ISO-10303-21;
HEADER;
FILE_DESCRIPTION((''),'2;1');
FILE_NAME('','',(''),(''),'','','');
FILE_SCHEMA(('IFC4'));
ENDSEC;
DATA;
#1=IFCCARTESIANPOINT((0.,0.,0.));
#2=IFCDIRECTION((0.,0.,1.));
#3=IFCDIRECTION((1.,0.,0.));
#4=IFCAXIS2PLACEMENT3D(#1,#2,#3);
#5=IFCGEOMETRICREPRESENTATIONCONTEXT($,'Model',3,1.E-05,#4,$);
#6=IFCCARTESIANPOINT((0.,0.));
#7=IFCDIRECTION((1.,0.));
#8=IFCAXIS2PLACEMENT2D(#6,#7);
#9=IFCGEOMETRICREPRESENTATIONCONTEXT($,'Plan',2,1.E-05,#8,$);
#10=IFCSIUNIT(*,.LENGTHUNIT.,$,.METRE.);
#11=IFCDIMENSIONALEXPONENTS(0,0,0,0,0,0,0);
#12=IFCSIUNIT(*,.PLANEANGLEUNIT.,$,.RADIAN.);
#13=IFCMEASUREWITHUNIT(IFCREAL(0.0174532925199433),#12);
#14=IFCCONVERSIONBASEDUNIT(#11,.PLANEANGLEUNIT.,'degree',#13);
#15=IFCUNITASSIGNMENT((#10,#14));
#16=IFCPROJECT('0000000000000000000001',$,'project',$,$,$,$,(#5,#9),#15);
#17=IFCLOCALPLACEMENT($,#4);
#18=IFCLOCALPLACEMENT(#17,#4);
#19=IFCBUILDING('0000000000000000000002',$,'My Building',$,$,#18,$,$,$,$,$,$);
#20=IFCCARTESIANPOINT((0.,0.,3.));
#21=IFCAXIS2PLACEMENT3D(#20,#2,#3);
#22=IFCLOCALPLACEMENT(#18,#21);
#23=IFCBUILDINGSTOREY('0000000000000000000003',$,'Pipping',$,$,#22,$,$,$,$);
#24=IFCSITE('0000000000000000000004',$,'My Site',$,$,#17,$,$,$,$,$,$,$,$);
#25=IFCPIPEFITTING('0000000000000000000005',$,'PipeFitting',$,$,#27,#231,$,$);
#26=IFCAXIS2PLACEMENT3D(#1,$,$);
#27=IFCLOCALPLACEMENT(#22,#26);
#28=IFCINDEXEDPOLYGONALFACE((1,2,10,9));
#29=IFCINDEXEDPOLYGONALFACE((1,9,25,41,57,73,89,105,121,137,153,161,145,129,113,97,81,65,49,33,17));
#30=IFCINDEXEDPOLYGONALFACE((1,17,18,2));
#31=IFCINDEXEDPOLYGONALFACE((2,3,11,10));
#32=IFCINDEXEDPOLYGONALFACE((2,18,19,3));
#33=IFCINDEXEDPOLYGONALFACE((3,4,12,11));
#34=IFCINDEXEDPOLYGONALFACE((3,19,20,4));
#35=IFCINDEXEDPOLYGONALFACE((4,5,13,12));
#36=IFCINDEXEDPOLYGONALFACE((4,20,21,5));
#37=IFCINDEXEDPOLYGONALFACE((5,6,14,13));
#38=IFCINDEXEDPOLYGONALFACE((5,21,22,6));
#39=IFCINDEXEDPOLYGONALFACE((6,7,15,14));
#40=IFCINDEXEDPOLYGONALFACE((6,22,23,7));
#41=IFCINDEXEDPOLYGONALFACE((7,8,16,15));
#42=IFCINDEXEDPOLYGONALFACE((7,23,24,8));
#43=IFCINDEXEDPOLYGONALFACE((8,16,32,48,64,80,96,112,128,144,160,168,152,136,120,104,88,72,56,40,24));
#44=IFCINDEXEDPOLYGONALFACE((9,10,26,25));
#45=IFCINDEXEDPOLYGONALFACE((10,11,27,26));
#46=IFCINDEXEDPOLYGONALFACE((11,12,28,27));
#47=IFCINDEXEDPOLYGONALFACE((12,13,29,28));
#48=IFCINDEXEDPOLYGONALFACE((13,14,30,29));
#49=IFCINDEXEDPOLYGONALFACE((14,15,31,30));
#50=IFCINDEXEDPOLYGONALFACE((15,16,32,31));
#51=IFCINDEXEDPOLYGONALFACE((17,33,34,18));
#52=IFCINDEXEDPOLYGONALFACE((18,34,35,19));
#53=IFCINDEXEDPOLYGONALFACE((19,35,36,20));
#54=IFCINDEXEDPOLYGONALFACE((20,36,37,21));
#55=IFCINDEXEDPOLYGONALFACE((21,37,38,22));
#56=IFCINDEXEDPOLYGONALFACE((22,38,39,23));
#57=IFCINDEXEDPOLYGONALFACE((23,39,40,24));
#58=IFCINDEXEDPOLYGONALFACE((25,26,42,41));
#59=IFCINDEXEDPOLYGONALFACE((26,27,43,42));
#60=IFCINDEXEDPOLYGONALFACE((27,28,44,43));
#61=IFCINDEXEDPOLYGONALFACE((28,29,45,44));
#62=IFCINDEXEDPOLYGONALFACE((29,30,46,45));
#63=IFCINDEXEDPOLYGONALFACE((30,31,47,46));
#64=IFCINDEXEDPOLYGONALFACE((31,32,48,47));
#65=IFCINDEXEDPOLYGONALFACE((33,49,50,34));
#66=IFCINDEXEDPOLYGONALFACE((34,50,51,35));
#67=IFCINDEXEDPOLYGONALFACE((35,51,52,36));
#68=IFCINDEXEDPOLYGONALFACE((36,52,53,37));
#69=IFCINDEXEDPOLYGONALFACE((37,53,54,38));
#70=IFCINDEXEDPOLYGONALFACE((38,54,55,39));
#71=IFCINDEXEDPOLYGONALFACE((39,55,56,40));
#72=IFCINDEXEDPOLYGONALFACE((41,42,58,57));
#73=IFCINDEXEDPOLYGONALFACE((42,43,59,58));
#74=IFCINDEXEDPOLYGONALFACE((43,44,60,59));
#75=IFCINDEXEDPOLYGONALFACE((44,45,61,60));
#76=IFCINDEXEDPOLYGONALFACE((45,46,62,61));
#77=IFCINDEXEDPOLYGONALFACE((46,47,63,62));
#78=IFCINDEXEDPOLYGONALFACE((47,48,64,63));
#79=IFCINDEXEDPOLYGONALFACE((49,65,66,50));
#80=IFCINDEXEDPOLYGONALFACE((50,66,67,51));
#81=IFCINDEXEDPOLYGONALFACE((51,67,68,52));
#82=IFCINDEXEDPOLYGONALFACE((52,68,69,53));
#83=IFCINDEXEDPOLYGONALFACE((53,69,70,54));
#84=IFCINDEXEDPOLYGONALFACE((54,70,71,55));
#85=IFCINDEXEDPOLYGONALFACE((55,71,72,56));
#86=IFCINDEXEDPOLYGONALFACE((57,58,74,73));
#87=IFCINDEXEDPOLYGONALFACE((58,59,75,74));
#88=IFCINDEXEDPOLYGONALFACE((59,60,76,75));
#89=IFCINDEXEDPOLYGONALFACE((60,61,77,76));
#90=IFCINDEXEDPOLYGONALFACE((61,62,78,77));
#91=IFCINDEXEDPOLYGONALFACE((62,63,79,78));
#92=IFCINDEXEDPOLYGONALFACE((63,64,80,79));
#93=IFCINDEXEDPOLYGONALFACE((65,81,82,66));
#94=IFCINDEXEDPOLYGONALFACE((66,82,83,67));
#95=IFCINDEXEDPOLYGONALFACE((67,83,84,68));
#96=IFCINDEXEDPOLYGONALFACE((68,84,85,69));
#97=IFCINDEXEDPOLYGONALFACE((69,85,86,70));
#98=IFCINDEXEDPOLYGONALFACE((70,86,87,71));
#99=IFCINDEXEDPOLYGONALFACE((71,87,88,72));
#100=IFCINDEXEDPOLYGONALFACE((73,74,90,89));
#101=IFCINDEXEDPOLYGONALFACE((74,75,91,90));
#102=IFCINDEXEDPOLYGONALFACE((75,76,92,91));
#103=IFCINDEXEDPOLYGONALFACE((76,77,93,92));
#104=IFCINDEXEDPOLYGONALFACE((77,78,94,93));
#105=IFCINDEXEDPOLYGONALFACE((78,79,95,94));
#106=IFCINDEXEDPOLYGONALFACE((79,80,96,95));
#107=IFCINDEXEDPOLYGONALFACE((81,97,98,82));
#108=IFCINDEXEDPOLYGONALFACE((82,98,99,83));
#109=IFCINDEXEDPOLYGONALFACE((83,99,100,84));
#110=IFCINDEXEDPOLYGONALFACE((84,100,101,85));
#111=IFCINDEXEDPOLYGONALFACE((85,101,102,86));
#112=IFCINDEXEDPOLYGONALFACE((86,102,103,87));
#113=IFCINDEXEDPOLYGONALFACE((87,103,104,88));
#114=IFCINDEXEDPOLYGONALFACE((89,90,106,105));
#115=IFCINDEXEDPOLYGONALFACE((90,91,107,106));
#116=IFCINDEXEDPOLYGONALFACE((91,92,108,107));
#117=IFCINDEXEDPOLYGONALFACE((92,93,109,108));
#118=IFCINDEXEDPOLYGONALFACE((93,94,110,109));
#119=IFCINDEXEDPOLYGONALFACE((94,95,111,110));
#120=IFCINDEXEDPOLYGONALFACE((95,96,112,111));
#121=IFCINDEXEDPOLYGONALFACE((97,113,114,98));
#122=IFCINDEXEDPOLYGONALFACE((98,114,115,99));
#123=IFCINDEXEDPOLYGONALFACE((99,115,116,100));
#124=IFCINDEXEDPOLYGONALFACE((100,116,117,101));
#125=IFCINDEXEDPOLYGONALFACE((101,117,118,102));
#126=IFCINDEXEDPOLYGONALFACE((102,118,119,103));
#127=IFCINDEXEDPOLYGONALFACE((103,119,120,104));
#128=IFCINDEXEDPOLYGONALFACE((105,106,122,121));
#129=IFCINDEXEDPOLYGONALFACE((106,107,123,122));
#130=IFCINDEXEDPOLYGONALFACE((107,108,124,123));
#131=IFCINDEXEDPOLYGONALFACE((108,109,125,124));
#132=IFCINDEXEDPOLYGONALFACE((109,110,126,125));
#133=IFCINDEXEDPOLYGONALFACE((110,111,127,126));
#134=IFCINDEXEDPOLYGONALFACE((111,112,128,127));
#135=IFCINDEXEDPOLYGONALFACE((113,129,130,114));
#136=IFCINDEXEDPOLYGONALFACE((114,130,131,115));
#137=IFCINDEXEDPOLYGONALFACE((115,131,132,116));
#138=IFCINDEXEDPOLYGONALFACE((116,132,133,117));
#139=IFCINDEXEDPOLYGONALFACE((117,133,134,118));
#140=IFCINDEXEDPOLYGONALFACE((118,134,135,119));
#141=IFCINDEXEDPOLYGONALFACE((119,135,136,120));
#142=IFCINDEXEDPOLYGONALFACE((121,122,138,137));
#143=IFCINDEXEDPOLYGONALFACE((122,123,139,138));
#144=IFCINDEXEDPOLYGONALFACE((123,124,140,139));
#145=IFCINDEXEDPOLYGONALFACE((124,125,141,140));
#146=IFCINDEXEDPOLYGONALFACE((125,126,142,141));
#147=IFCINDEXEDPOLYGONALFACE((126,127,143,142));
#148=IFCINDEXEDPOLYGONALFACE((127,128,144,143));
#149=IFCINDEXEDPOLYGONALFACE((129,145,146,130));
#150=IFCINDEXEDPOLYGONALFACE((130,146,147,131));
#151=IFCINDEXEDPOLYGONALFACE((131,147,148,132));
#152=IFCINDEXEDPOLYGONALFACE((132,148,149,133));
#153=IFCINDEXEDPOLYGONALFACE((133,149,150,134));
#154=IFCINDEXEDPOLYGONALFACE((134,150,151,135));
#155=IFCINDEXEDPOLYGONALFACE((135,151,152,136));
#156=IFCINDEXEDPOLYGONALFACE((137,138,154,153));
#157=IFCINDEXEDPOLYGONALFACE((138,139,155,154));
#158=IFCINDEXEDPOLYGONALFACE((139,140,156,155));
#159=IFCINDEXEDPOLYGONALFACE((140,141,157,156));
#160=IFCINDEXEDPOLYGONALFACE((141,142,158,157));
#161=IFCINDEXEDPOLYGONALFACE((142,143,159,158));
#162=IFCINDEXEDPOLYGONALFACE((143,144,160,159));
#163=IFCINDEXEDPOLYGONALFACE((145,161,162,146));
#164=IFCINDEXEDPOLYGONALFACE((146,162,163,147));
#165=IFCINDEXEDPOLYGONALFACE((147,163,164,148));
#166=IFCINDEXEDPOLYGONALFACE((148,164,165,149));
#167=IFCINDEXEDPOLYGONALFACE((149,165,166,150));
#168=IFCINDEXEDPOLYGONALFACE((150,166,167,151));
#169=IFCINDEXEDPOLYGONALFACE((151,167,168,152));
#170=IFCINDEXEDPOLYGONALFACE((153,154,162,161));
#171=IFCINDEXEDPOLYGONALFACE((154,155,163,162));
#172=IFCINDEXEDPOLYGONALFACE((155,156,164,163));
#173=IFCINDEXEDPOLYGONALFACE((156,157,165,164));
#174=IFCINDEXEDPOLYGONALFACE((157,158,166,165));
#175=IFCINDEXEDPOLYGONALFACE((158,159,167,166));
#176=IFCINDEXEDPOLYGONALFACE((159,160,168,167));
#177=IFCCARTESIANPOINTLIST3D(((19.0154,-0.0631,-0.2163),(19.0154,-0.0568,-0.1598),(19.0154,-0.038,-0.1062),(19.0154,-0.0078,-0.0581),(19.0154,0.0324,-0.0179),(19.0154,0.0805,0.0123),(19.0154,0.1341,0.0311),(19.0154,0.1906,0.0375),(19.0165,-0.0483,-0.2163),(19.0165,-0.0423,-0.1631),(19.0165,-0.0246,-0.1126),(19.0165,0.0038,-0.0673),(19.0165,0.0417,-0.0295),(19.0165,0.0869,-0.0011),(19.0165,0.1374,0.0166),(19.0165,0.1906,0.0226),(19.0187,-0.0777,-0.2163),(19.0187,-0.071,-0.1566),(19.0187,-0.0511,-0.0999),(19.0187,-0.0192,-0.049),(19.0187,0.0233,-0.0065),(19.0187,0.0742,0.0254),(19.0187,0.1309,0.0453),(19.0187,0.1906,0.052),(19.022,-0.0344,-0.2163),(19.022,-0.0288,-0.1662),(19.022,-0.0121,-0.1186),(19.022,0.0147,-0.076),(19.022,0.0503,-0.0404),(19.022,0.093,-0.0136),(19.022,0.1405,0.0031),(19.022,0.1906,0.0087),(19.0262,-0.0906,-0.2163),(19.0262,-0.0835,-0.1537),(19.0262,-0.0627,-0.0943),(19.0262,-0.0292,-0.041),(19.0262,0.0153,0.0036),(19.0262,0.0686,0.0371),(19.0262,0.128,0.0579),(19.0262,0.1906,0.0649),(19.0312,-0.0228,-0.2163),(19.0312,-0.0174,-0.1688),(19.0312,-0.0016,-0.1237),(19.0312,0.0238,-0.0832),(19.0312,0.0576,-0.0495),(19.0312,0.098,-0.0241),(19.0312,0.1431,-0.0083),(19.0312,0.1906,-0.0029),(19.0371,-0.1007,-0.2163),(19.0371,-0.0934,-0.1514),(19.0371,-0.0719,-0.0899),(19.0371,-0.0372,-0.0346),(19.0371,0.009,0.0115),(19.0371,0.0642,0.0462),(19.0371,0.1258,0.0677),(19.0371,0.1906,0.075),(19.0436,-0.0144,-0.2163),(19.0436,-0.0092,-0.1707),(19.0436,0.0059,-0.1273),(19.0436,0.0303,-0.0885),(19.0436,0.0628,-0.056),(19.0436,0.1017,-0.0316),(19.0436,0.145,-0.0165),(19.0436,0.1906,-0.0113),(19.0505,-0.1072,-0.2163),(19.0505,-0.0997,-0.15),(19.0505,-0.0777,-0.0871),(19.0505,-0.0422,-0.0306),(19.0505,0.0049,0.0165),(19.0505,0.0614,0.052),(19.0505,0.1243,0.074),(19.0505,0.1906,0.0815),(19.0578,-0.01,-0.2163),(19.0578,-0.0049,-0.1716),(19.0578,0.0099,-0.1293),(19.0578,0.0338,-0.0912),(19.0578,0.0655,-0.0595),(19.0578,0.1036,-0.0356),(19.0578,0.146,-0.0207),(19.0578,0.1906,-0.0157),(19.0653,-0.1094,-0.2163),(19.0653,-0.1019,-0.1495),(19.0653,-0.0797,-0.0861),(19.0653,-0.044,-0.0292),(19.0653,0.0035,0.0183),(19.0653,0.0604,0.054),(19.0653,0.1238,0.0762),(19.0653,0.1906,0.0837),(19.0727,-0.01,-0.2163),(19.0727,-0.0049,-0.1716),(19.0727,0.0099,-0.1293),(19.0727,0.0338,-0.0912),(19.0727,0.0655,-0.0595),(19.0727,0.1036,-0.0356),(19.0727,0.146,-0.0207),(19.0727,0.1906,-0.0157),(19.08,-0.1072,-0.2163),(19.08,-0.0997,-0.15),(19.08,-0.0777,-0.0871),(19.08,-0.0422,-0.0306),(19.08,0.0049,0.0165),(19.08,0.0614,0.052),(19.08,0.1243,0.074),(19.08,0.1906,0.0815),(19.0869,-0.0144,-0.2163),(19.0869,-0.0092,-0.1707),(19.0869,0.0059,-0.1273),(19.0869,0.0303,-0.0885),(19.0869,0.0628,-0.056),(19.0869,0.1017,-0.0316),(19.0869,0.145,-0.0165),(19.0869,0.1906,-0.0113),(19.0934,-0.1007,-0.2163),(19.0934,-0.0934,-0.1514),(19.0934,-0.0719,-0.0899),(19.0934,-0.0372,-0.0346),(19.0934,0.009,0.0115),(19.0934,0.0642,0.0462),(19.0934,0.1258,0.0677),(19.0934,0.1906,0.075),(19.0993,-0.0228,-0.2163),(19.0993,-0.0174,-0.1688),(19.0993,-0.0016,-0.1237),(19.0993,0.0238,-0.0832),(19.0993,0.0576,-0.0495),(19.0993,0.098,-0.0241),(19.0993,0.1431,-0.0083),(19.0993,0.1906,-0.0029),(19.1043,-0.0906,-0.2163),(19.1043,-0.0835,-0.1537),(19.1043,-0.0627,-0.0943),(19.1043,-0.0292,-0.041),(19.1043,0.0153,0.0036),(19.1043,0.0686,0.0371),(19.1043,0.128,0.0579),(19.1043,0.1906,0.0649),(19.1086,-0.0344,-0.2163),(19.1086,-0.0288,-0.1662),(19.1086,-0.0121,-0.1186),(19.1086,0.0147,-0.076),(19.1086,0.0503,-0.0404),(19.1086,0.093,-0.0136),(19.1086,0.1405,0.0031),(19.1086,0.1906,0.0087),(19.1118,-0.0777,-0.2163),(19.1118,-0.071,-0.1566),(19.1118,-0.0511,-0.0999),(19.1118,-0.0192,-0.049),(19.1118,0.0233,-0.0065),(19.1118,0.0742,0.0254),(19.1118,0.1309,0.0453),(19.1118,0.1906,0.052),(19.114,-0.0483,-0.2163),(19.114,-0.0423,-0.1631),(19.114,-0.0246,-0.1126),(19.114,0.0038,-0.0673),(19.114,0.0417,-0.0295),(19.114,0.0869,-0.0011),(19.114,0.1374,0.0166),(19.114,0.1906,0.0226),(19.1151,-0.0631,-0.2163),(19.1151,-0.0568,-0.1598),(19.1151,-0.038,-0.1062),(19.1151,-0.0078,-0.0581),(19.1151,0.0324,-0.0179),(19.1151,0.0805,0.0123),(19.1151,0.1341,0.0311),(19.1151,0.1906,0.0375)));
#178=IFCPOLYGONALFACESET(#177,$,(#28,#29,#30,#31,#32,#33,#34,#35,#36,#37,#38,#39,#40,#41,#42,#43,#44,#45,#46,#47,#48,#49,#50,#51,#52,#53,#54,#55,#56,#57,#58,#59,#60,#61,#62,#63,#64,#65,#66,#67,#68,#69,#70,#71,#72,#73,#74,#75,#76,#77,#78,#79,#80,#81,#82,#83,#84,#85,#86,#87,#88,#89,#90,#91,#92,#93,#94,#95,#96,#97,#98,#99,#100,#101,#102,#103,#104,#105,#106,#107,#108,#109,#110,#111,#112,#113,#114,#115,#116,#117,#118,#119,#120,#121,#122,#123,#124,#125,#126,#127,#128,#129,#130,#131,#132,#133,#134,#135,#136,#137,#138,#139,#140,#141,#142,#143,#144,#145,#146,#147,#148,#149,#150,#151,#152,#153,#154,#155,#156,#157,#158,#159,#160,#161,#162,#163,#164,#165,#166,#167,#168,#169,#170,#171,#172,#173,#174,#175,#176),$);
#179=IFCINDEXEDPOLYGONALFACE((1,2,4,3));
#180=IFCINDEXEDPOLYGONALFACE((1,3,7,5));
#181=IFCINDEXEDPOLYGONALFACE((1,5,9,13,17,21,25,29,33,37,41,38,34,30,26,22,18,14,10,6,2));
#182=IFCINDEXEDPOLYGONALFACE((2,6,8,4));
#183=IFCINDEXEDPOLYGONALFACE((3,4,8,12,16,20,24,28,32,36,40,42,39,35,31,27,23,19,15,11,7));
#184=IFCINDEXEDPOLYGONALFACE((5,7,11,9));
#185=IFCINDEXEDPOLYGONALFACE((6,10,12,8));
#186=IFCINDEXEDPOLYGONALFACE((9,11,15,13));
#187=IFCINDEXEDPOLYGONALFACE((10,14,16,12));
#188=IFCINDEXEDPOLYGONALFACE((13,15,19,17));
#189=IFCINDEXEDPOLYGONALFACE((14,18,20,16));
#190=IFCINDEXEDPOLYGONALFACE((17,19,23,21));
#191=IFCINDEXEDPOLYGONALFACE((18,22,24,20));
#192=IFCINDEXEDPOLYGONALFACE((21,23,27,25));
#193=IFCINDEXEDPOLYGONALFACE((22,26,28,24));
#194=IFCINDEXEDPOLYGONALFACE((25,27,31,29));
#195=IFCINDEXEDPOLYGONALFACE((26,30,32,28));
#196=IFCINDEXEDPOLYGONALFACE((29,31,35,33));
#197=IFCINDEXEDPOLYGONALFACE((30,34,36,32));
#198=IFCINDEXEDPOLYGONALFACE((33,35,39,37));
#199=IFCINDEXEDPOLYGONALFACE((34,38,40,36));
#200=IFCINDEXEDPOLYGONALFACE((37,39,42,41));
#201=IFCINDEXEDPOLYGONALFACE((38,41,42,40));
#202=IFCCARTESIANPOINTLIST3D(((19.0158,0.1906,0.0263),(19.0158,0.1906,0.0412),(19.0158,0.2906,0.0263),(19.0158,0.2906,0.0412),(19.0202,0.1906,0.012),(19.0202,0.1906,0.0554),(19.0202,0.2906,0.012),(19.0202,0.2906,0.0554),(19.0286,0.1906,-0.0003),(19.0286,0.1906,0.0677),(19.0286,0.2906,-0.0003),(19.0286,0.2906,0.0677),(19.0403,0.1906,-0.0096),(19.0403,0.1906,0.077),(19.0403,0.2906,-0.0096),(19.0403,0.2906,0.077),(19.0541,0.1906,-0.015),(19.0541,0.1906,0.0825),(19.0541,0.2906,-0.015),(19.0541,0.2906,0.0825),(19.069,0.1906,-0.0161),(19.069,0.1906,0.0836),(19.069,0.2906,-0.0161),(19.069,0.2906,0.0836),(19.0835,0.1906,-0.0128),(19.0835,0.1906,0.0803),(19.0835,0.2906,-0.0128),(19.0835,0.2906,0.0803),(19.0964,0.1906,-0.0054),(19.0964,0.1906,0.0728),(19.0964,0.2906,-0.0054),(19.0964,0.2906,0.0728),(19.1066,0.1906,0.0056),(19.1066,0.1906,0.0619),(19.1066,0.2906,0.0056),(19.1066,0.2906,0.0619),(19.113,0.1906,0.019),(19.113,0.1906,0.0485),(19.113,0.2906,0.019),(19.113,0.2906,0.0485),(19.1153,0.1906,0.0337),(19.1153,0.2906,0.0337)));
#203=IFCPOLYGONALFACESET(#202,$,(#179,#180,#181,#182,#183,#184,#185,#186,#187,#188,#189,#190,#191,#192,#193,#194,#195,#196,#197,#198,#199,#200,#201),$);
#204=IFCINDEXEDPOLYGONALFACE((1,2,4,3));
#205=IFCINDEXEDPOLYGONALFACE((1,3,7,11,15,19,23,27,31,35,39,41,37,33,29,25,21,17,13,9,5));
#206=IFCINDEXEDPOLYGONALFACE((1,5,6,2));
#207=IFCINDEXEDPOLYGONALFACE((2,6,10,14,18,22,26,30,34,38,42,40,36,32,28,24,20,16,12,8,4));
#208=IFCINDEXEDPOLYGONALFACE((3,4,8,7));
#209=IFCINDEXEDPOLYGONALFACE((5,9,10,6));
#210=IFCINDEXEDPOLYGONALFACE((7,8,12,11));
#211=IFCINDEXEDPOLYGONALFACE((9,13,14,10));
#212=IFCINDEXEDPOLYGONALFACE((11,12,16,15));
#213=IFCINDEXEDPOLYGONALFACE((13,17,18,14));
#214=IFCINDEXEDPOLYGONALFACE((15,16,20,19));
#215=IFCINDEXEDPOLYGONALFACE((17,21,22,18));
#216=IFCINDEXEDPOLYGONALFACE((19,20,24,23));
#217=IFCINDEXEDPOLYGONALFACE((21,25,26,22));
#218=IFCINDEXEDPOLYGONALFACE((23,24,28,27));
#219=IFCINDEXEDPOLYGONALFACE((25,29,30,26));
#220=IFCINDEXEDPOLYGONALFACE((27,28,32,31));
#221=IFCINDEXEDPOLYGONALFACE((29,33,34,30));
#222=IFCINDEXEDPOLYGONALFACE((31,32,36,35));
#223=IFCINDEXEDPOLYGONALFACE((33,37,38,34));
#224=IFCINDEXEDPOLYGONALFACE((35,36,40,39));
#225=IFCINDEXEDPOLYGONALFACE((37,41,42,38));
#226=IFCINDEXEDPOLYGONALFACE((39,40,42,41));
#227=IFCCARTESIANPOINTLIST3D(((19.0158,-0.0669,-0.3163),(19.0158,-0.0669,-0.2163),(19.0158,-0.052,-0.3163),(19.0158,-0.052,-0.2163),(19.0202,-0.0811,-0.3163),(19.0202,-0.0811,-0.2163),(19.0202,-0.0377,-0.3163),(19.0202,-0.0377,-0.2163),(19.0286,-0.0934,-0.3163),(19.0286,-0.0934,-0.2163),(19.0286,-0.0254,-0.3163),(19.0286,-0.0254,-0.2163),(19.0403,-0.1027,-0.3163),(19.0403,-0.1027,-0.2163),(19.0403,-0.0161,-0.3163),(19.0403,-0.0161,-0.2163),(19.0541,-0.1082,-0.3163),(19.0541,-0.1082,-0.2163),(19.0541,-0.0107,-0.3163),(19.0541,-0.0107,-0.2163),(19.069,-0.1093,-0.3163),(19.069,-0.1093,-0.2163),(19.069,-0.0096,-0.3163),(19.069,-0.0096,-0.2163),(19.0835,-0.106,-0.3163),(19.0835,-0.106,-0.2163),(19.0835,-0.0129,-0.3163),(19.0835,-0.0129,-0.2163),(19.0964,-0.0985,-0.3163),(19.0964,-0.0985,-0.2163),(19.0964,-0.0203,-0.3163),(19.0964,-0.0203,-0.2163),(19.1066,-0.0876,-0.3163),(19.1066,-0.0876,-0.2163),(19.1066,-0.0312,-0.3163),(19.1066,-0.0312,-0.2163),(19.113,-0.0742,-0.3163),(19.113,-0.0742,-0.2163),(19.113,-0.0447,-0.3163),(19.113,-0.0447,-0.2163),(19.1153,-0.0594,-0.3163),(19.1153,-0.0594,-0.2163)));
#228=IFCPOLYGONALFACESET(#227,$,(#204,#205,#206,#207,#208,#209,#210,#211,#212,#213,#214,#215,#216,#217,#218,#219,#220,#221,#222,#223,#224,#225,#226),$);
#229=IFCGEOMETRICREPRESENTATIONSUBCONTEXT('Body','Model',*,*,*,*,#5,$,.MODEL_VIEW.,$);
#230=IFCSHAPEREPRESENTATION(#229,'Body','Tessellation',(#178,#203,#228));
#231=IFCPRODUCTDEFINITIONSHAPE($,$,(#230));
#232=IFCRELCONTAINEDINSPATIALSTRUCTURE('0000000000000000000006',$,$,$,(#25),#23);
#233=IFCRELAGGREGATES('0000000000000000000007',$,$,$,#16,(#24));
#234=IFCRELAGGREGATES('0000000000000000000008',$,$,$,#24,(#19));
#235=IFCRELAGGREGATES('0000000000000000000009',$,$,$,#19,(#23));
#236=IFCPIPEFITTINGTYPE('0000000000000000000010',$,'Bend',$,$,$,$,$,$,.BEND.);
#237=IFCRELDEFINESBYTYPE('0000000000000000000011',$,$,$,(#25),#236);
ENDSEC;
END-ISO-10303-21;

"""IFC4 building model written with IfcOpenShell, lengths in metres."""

from ifc_helpers import new_model, entity, si_unit, converted_unit, frame, origin_with_axes, origin_2d_with_axis, place, context, subcontext, project, spatial, circle, extrude, source, transform, mapped, type_object, type_shapes, element, save


model = new_model("IFC4")

# Units and contexts
model_context = context("Model", 3, precision=1e-05, world=origin_with_axes())
plan_context = context("Plan", 2, precision=1e-05, world=origin_2d_with_axis())
body_context = subcontext(model_context, "Body", "Model", "MODEL_VIEW")
ifc_project = project(units=[si_unit("LENGTHUNIT", "METRE"), converted_unit("PLANEANGLEUNIT", "degree", entity("IfcReal", 0.0174532925199433), si_unit("PLANEANGLEUNIT", "RADIAN"), dimensions=[0, 0, 0, 0, 0, 0, 0])], contexts=[model_context, plan_context])

# Site, building, storey
site_placement = place(None, origin_with_axes())
site = spatial("IfcSite", under=ifc_project, at=site_placement, Name="My Site")
building_placement = place(site_placement, origin_with_axes())
building = spatial("IfcBuilding", under=site, at=building_placement, Name="My Building")
storey_placement = place(building_placement, frame((0.0, 0.0, 3.0), z_axis=(0.0, 0.0, 1.0), x_axis=(1.0, 0.0, 0.0)))
storey = spatial("IfcBuildingStorey", under=building, at=storey_placement, Name="Pipping")

# Pipe fitting
pipe_fitting_type_1 = type_object("IfcPipeFittingType", Name="Bend", PredefinedType="BEND")
shared_shape_1 = source(origin_with_axes(), body_context, "Body", "SolidModel", [
    entity("IfcSweptDiskSolid", entity("IfcIndexedPolyCurve", entity("IfcCartesianPointList3D", [[0.0, 0.0, 0.1], [0.0, -0.0732, 0.2768], [0.0, -0.25, 0.35]]), [entity("IfcArcIndex", [1, 2, 3])]), 0.05),
    extrude(circle(Radius=0.05), origin_with_axes(), (0.0, 0.0, 1.0), 0.1),
    extrude(circle(Radius=0.05), frame((0.0, -0.25, 0.35), z_axis=(0.0, -1.0, 0.0), x_axis=(1.0, 0.0, 0.0)), (0.0, 0.0, 1.0), 0.1),
])
type_shapes(pipe_fitting_type_1, [shared_shape_1])
for number, where, z_axis, x_axis, name in (
    (1, (19.0653, 0.2906, 0.0337), (0.0, -1.0, 0.0), (1.0, 0.0, 0.0), "PipeFitting"),
):
    element("IfcPipeFitting", number, at=place(storey_placement, frame(where, z_axis=z_axis, x_axis=x_axis)), inside=storey, type_object=pipe_fitting_type_1, Name=name, context=body_context, shape_type="MappedRepresentation", body=[
        mapped(shared_shape_1, transform((0.0, 0.0, 0.0), x_axis=(1.0, 0.0, 0.0), y_axis=(0.0, 1.0, 0.0), z_axis=(0.0, 0.0, 1.0), scale=1.0)),
    ])

save(model, "model.ifc")
